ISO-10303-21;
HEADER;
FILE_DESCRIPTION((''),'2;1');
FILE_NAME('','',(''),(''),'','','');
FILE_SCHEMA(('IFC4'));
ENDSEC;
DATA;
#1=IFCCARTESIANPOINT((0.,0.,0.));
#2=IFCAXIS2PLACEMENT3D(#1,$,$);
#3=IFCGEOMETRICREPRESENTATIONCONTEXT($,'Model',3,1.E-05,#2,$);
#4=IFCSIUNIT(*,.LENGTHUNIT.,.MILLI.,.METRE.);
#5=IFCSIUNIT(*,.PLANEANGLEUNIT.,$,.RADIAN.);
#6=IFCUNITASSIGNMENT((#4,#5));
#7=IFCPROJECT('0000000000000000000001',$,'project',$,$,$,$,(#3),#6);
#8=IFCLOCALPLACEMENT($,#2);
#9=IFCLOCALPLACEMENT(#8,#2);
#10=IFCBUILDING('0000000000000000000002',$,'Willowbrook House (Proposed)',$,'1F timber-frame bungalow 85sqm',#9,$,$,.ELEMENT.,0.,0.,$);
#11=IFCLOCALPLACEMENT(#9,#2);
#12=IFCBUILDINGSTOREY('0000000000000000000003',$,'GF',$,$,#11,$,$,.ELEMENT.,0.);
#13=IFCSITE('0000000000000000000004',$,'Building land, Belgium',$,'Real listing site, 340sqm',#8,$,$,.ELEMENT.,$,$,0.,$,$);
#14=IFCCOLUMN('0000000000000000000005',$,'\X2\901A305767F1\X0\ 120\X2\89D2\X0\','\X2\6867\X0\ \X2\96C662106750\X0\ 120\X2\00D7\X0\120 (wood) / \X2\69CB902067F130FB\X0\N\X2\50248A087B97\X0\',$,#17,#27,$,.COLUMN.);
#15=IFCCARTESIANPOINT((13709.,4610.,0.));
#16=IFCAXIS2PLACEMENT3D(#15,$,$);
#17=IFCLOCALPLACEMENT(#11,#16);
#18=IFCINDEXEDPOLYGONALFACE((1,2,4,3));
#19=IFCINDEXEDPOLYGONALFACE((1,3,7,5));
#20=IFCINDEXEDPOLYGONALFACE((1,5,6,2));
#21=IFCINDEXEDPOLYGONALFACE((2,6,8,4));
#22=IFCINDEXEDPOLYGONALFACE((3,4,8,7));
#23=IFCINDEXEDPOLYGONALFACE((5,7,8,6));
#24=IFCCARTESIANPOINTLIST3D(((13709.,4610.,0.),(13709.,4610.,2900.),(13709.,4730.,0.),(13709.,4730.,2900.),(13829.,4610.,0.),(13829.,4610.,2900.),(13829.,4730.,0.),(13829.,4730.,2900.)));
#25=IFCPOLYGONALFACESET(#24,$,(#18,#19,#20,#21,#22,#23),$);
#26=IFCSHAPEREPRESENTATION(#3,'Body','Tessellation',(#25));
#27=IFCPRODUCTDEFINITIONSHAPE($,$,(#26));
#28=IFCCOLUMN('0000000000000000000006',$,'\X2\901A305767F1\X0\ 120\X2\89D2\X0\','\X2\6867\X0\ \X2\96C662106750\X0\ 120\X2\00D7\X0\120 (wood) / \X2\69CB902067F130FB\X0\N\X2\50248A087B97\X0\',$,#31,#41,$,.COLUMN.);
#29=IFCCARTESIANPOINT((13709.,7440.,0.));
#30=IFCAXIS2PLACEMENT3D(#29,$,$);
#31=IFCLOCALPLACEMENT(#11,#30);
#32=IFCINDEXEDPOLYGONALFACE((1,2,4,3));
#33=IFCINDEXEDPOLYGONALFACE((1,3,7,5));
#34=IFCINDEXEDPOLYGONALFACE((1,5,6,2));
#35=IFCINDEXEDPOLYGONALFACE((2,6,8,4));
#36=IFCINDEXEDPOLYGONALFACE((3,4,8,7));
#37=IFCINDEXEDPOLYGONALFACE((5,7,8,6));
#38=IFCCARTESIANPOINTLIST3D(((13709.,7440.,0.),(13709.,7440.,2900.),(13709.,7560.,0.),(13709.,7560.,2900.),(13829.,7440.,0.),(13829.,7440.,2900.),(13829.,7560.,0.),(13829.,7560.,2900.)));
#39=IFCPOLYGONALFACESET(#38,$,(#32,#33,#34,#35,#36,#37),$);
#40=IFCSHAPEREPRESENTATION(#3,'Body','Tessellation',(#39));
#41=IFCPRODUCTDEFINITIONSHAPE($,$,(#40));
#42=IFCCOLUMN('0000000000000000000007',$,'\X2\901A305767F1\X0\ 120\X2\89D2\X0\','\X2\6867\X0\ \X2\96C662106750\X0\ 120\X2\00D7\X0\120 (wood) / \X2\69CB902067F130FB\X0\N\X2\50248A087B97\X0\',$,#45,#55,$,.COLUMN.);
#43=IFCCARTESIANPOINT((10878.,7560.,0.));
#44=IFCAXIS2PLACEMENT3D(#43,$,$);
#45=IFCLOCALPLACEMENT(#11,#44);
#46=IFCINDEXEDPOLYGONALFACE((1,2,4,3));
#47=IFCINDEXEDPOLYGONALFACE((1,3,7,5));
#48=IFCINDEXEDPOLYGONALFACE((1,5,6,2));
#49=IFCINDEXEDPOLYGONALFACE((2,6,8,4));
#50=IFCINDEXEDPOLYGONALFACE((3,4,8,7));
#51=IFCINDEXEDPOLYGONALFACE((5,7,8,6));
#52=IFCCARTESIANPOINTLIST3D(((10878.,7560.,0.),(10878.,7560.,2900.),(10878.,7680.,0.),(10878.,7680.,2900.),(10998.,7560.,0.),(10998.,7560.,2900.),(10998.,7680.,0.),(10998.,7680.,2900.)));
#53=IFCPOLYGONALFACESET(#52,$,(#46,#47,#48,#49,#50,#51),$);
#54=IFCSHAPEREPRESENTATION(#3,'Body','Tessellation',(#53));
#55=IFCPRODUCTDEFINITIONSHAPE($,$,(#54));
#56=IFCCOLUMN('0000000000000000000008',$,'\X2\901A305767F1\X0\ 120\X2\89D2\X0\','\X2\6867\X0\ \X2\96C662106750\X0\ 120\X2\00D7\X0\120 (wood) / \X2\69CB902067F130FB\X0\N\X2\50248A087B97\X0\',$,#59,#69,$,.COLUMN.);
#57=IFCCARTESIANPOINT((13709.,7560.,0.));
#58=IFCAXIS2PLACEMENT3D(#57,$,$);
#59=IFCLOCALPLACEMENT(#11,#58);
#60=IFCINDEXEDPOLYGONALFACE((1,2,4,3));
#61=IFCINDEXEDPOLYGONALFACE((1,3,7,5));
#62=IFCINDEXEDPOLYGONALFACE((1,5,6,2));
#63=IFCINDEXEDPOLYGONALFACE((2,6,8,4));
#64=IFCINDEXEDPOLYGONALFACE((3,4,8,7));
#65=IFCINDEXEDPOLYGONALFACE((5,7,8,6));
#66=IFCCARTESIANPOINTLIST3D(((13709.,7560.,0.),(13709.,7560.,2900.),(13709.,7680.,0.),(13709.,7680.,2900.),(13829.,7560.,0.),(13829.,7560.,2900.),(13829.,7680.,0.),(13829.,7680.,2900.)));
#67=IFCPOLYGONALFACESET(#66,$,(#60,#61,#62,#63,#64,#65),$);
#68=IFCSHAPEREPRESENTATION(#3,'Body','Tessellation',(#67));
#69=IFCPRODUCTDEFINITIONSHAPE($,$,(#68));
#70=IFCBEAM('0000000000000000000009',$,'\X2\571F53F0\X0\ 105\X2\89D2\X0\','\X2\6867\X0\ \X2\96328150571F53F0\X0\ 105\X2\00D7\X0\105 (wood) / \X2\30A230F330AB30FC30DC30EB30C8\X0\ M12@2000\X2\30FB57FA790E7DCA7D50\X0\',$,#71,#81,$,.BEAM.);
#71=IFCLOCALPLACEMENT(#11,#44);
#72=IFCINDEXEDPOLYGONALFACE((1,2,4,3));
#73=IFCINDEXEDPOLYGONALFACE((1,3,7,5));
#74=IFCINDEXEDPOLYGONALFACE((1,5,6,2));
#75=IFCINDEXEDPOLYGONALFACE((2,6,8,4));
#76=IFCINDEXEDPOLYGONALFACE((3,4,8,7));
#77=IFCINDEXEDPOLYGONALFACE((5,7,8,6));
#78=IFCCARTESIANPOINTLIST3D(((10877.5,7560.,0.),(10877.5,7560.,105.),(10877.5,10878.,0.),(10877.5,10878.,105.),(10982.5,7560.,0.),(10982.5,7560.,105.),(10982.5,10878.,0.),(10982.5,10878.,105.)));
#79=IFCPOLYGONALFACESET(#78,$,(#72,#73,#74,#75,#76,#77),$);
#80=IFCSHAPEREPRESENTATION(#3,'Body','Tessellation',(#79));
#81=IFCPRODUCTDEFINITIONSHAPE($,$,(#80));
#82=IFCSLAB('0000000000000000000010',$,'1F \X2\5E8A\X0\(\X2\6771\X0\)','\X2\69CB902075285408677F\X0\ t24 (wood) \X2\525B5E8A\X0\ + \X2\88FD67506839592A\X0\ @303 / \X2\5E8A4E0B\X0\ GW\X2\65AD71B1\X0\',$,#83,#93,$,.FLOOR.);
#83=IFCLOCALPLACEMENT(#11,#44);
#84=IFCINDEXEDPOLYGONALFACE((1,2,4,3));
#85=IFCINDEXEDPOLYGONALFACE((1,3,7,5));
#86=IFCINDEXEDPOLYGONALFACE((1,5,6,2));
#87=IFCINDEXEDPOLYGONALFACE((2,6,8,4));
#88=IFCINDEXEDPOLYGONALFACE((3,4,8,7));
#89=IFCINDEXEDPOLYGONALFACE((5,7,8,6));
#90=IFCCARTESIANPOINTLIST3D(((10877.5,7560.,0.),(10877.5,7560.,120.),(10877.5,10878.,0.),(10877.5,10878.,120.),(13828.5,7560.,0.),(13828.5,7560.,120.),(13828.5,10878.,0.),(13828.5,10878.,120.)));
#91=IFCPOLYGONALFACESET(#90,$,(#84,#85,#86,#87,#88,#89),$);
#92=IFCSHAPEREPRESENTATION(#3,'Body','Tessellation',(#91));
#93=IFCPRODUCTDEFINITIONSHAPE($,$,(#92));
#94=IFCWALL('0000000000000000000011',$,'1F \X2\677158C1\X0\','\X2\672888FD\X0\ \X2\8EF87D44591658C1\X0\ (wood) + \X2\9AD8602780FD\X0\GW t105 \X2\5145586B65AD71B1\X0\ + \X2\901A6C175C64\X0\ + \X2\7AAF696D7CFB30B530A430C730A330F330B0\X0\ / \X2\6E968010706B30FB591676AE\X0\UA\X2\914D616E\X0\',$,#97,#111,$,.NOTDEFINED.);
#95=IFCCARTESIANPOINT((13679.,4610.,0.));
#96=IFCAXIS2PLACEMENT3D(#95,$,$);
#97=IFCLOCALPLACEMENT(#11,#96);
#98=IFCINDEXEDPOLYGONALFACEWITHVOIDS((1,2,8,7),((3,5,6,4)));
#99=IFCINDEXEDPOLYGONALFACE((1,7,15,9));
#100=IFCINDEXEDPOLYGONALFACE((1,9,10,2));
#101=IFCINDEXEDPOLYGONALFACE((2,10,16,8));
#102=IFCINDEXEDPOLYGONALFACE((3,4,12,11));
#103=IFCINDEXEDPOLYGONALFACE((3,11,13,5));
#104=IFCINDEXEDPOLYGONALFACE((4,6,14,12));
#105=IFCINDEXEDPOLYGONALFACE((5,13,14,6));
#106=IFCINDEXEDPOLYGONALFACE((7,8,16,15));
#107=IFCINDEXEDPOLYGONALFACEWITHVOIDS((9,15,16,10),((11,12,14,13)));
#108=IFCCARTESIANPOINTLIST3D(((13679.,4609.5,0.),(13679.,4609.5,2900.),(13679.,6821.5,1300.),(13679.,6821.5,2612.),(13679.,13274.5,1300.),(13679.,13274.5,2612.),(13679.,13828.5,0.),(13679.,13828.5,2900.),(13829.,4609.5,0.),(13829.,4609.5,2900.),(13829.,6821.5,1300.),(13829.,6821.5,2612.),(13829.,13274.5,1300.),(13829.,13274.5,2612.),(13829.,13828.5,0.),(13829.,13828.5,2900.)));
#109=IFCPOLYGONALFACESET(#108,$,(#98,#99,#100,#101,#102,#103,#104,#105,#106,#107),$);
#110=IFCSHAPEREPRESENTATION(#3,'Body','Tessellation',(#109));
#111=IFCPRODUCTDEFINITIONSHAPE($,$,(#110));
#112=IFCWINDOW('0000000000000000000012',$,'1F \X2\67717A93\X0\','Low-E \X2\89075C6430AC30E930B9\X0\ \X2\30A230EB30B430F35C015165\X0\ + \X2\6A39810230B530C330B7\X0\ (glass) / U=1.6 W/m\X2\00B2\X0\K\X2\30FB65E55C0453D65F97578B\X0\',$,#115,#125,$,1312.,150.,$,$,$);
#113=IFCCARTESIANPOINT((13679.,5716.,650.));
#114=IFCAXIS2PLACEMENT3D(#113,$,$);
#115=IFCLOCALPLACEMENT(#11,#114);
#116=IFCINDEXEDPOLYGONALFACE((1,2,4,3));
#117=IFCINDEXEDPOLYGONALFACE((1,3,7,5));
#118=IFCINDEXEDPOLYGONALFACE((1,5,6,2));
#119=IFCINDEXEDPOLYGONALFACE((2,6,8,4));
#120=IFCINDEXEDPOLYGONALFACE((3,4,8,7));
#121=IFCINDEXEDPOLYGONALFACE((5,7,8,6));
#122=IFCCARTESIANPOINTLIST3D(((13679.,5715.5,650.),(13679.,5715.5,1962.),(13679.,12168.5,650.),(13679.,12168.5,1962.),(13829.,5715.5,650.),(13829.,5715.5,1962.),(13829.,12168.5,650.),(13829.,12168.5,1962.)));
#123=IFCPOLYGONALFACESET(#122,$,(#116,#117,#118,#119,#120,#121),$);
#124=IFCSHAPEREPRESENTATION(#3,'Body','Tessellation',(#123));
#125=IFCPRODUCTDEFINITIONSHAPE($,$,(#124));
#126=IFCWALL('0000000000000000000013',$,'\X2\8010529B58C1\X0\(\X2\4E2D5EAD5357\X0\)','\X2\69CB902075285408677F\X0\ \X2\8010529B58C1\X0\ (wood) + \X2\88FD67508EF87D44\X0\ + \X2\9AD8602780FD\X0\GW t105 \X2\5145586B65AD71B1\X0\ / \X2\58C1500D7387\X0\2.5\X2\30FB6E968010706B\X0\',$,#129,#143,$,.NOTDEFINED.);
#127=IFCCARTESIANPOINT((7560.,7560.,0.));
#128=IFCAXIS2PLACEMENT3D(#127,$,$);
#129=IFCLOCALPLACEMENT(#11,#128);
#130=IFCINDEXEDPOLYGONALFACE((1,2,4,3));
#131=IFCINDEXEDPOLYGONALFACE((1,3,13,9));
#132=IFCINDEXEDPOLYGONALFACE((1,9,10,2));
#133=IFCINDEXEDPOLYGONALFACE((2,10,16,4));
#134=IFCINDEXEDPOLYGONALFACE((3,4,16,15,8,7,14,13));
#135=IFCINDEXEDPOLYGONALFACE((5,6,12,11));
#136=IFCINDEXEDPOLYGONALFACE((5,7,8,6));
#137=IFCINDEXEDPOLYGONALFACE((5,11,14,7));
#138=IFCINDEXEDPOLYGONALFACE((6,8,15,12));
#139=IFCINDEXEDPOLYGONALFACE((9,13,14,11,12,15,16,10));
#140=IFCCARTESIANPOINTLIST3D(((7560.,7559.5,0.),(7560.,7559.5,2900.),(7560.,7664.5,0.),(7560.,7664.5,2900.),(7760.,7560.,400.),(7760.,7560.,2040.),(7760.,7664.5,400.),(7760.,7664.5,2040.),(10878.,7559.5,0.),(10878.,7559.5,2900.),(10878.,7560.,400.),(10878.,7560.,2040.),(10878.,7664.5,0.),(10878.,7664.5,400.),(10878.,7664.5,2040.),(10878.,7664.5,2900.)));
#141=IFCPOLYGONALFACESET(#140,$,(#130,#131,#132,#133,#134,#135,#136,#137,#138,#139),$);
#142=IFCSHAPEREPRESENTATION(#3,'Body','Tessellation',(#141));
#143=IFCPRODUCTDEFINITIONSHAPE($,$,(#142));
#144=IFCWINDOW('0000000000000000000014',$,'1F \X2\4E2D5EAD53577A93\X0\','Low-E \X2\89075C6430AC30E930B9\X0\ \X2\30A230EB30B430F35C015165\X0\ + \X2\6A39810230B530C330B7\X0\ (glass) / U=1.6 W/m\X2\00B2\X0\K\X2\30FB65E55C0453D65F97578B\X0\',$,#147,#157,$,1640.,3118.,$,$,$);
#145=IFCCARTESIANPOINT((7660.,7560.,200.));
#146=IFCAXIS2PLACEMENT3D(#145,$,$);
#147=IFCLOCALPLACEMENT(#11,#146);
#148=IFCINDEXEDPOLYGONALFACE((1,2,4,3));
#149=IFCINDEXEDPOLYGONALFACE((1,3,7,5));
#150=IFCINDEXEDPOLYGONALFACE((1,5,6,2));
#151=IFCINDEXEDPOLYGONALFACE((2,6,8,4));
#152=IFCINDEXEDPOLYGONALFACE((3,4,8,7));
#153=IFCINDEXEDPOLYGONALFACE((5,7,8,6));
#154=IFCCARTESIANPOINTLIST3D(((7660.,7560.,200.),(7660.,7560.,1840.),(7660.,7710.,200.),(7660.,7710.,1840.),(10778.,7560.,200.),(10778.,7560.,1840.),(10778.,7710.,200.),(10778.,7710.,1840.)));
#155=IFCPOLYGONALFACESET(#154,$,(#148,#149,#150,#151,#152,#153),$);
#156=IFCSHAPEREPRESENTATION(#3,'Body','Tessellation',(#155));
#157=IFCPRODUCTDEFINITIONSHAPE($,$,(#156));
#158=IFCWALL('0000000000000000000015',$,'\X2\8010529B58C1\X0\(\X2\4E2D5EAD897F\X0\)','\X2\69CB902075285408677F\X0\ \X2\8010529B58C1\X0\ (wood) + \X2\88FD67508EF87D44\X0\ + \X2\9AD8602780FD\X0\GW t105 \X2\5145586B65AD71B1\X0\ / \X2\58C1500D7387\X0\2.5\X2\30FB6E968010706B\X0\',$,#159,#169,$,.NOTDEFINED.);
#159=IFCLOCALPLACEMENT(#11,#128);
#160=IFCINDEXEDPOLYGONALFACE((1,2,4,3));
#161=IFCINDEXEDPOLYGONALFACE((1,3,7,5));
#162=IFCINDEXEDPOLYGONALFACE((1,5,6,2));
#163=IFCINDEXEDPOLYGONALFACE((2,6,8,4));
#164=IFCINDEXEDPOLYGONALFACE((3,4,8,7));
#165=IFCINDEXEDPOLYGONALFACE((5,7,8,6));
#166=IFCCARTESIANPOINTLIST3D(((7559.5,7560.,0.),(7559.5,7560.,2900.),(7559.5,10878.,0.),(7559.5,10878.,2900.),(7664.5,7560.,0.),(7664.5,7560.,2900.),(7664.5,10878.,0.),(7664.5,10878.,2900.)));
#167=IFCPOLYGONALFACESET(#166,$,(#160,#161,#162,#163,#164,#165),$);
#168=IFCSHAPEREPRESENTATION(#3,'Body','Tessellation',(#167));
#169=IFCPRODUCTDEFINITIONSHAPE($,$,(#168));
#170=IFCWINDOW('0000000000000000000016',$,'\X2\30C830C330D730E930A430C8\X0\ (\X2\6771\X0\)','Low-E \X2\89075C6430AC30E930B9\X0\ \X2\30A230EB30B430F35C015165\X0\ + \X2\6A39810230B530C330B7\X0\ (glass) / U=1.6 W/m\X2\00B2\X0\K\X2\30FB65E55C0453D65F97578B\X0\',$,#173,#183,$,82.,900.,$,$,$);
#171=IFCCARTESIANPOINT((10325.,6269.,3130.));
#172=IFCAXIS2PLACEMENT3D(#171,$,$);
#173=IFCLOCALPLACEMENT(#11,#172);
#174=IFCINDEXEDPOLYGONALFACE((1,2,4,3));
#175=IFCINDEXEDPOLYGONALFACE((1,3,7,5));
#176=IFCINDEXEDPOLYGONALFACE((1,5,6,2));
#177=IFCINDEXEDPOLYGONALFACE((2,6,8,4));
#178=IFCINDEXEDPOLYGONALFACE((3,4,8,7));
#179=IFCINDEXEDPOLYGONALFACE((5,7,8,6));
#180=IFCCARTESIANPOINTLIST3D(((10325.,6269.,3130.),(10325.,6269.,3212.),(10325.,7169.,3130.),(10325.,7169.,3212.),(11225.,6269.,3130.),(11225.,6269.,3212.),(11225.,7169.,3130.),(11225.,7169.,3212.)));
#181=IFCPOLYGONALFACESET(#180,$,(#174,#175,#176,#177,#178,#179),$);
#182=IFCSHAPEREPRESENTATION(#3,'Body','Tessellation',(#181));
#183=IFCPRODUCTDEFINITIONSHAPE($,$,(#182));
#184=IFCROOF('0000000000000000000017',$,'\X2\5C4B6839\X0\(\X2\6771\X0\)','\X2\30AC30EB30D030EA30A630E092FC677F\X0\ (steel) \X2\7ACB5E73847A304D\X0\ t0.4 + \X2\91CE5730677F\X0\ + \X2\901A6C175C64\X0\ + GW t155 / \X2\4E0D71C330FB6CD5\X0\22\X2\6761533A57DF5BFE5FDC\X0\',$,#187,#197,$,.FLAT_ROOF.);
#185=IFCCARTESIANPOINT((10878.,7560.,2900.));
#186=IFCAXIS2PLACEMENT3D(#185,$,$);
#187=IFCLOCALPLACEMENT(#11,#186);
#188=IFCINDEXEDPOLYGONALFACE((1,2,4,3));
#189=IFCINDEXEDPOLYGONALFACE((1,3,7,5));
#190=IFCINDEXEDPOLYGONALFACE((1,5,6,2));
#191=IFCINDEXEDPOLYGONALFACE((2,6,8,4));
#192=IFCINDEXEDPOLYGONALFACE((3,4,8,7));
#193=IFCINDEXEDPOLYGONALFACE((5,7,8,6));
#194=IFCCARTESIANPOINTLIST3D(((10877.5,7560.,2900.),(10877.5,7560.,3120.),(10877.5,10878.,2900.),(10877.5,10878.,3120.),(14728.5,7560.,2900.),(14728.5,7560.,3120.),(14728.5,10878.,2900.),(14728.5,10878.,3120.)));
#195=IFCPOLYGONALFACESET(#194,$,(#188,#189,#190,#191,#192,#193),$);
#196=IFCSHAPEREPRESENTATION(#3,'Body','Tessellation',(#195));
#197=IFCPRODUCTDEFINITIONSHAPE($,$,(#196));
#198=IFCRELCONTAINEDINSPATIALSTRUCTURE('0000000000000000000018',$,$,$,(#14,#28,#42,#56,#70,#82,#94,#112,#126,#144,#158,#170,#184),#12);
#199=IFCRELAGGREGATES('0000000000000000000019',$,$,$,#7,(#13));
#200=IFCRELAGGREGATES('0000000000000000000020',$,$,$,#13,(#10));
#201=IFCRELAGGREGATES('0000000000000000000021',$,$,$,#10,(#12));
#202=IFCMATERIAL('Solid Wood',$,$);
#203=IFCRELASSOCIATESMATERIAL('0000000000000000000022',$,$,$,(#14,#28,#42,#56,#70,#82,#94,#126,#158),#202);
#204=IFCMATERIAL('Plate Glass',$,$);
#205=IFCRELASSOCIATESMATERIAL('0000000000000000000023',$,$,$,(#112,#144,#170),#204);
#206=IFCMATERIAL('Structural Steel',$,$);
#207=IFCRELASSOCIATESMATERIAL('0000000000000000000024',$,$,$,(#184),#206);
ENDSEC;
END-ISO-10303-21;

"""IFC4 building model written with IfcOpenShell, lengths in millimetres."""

from ifc_helpers import new_model, si_unit, frame, frame_2d, origin, place, context, project, spatial, rectangle, extrude, material, element, fill, save


model = new_model("IFC4")

# Units and contexts
model_context = context("Model", 3, precision=1e-05, world=origin())
ifc_project = project(units=[si_unit("LENGTHUNIT", "METRE", prefix="MILLI"), si_unit("PLANEANGLEUNIT", "RADIAN")], contexts=[model_context])

# Site, building, storey
site_placement = place(None, origin())
site = spatial("IfcSite", under=ifc_project, at=site_placement, Name="Building land, Belgium", ObjectType="Real listing site, 340sqm", CompositionType="ELEMENT", RefElevation=0.0)
building_placement = place(site_placement, origin())
building = spatial("IfcBuilding", under=site, at=building_placement, Name="Willowbrook House (Proposed)", ObjectType="1F timber-frame bungalow 85sqm", CompositionType="ELEMENT", ElevationOfRefHeight=0.0, ElevationOfTerrain=0.0)
storey_placement = place(building_placement, origin())
storey = spatial("IfcBuildingStorey", under=building, at=storey_placement, Name="GF", CompositionType="ELEMENT", Elevation=0.0)

# Columns
ifc_material_1 = material(Name="Solid Wood")
column_1_placement = place(storey_placement, frame((13709.0, 4610.0, 0.0)))
element("IfcColumn", 1, at=column_1_placement, inside=storey, material=ifc_material_1, Name="通し柱 120角", Description="桧 集成材 120×120 (wood) / 構造柱・N値計算", PredefinedType="COLUMN", context=model_context, shape_type="SweptSolid", body=[
    extrude(rectangle(XDim=120.0, YDim=120.0, at=frame_2d((60.0, 60.0))), frame((13709.0, 4610.0, 0.0)), (0.0, 0.0, 1.0), 2900.0),
])
column_2_placement = place(storey_placement, frame((13709.0, 7440.0, 0.0)))
element("IfcColumn", 2, at=column_2_placement, inside=storey, material=ifc_material_1, Name="通し柱 120角", Description="桧 集成材 120×120 (wood) / 構造柱・N値計算", PredefinedType="COLUMN", context=model_context, shape_type="SweptSolid", body=[
    extrude(rectangle(XDim=120.0, YDim=120.0, at=frame_2d((60.0, 60.0))), frame((13709.0, 7440.0, 0.0)), (0.0, 0.0, 1.0), 2900.0),
])
column_3_placement = place(storey_placement, frame((10878.0, 7560.0, 0.0)))
element("IfcColumn", 3, at=column_3_placement, inside=storey, material=ifc_material_1, Name="通し柱 120角", Description="桧 集成材 120×120 (wood) / 構造柱・N値計算", PredefinedType="COLUMN", context=model_context, shape_type="SweptSolid", body=[
    extrude(rectangle(XDim=120.0, YDim=120.0, at=frame_2d((60.0, 60.0))), frame((10878.0, 7560.0, 0.0)), (0.0, 0.0, 1.0), 2900.0),
])
column_4_placement = place(storey_placement, frame((13709.0, 7560.0, 0.0)))
element("IfcColumn", 4, at=column_4_placement, inside=storey, material=ifc_material_1, Name="通し柱 120角", Description="桧 集成材 120×120 (wood) / 構造柱・N値計算", PredefinedType="COLUMN", context=model_context, shape_type="SweptSolid", body=[
    extrude(rectangle(XDim=120.0, YDim=120.0, at=frame_2d((60.0, 60.0))), frame((13709.0, 7560.0, 0.0)), (0.0, 0.0, 1.0), 2900.0),
])

# Beam
beam_1_placement = place(storey_placement, frame((10878.0, 7560.0, 0.0)))
element("IfcBeam", 5, at=beam_1_placement, inside=storey, material=ifc_material_1, Name="土台 105角", Description="桧 防腐土台 105×105 (wood) / アンカーボルト M12@2000・基礎緊結", PredefinedType="BEAM", context=model_context, shape_type="SweptSolid", body=[
    extrude(rectangle(XDim=105.0, YDim=3318.0, at=frame_2d((52.0, 1659.0))), frame((10878.0, 7560.0, 0.0)), (0.0, 0.0, 1.0), 105.0),
])

# Slab
slab_placement = place(storey_placement, frame((10878.0, 7560.0, 0.0)))
element("IfcSlab", 6, at=slab_placement, inside=storey, material=ifc_material_1, Name="1F 床(東)", Description="構造用合板 t24 (wood) 剛床 + 製材根太 @303 / 床下 GW断熱", PredefinedType="FLOOR", context=model_context, shape_type="SweptSolid", body=[
    extrude(rectangle(XDim=2951.0, YDim=3318.0, at=frame_2d((1475.0, 1659.0))), frame((10878.0, 7560.0, 0.0)), (0.0, 0.0, 1.0), 120.0),
])

# Walls, openings, windows
wall_1_placement = place(storey_placement, frame((13679.0, 4610.0, 0.0)))
wall_1 = element("IfcWall", 7, at=wall_1_placement, inside=storey, material=ifc_material_1, Name="1F 東壁", Description="木製 軸組外壁 (wood) + 高性能GW t105 充填断熱 + 通気層 + 窯業系サイディング / 準耐火・外皮UA配慮", PredefinedType="NOTDEFINED", context=model_context, shape_type="SweptSolid", body=[
    extrude(rectangle(XDim=150.0, YDim=9219.0, at=frame_2d((75.0, 4609.0))), frame((13679.0, 4610.0, 0.0)), (0.0, 0.0, 1.0), 2900.0),
])
opening_1_placement = place(storey_placement, frame((13679.0, 5716.0, 650.0)))
opening_1 = element("IfcOpeningElement", 8, at=opening_1_placement, cuts=wall_1, PredefinedType="NOTDEFINED", context=model_context, shape_type="SweptSolid", body=[
    extrude(rectangle(XDim=150.0, YDim=6453.0, at=frame_2d((75.0, 3226.0))), frame((13679.0, 5716.0, 650.0)), (0.0, 0.0, 1.0), 1312.0),
])
ifc_material_2 = material(Name="Plate Glass")
window_1_placement = place(storey_placement, frame((13679.0, 5716.0, 650.0)))
window_1 = element("IfcWindow", 9, at=window_1_placement, inside=storey, material=ifc_material_2, Name="1F 東窓", Description="Low-E 複層ガラス アルゴン封入 + 樹脂サッシ (glass) / U=1.6 W/m²K・日射取得型", OverallHeight=1312.0, OverallWidth=150.0, context=model_context, shape_type="SweptSolid", body=[
    extrude(rectangle(XDim=150.0, YDim=6453.0, at=frame_2d((75.0, 3226.0))), frame((13679.0, 5716.0, 650.0)), (0.0, 0.0, 1.0), 1312.0),
])
fill(opening_1, window_1)
wall_2_placement = place(storey_placement, frame((7560.0, 7560.0, 0.0)))
wall_2 = element("IfcWall", 10, at=wall_2_placement, inside=storey, material=ifc_material_1, Name="耐力壁(中庭南)", Description="構造用合板 耐力壁 (wood) + 製材軸組 + 高性能GW t105 充填断熱 / 壁倍率2.5・準耐火", PredefinedType="NOTDEFINED", context=model_context, shape_type="SweptSolid", body=[
    extrude(rectangle(XDim=3318.0, YDim=105.0, at=frame_2d((1659.0, 52.0))), frame((7560.0, 7560.0, 0.0)), (0.0, 0.0, 1.0), 2900.0),
])
opening_2_placement = place(storey_placement, frame((7660.0, 7560.0, 200.0)))
opening_2 = element("IfcOpeningElement", 11, at=opening_2_placement, cuts=wall_2, PredefinedType="NOTDEFINED", context=model_context, shape_type="SweptSolid", body=[
    extrude(rectangle(XDim=3118.0, YDim=150.0, at=frame_2d((1559.0, 75.0))), frame((7660.0, 7560.0, 200.0)), (0.0, 0.0, 1.0), 1640.0),
])
window_2_placement = place(storey_placement, frame((7660.0, 7560.0, 200.0)))
window_2 = element("IfcWindow", 12, at=window_2_placement, inside=storey, material=ifc_material_2, Name="1F 中庭南窓", Description="Low-E 複層ガラス アルゴン封入 + 樹脂サッシ (glass) / U=1.6 W/m²K・日射取得型", OverallHeight=1640.0, OverallWidth=3118.0, context=model_context, shape_type="SweptSolid", body=[
    extrude(rectangle(XDim=3118.0, YDim=150.0, at=frame_2d((1559.0, 75.0))), frame((7660.0, 7560.0, 200.0)), (0.0, 0.0, 1.0), 1640.0),
])
fill(opening_2, window_2)

# Wall
wall_3_placement = place(storey_placement, frame((7560.0, 7560.0, 0.0)))
element("IfcWall", 13, at=wall_3_placement, inside=storey, material=ifc_material_1, Name="耐力壁(中庭西)", Description="構造用合板 耐力壁 (wood) + 製材軸組 + 高性能GW t105 充填断熱 / 壁倍率2.5・準耐火", PredefinedType="NOTDEFINED", context=model_context, shape_type="SweptSolid", body=[
    extrude(rectangle(XDim=105.0, YDim=3318.0, at=frame_2d((52.0, 1659.0))), frame((7560.0, 7560.0, 0.0)), (0.0, 0.0, 1.0), 2900.0),
])

# Window
window_3_placement = place(storey_placement, frame((10325.0, 6269.0, 3130.0)))
element("IfcWindow", 14, at=window_3_placement, inside=storey, material=ifc_material_2, Name="トップライト (東)", Description="Low-E 複層ガラス アルゴン封入 + 樹脂サッシ (glass) / U=1.6 W/m²K・日射取得型", OverallHeight=82.0, OverallWidth=900.0, context=model_context, shape_type="SweptSolid", body=[
    extrude(rectangle(XDim=900.0, YDim=900.0, at=frame_2d((450.0, 450.0))), frame((10325.0, 6269.0, 3130.0)), (0.0, 0.0, 1.0), 82.0),
])

# Roof
ifc_material_3 = material(Name="Structural Steel")
roof_placement = place(storey_placement, frame((10878.0, 7560.0, 2900.0)))
element("IfcRoof", 15, at=roof_placement, inside=storey, material=ifc_material_3, Name="屋根(東)", Description="ガルバリウム鋼板 (steel) 立平葺き t0.4 + 野地板 + 通気層 + GW t155 / 不燃・法22条区域対応", PredefinedType="FLAT_ROOF", context=model_context, shape_type="SweptSolid", body=[
    extrude(rectangle(XDim=3851.0, YDim=3318.0, at=frame_2d((1925.0, 1659.0))), frame((10878.0, 7560.0, 2900.0)), (0.0, 0.0, 1.0), 220.0),
])

save(model, "model.ifc")
